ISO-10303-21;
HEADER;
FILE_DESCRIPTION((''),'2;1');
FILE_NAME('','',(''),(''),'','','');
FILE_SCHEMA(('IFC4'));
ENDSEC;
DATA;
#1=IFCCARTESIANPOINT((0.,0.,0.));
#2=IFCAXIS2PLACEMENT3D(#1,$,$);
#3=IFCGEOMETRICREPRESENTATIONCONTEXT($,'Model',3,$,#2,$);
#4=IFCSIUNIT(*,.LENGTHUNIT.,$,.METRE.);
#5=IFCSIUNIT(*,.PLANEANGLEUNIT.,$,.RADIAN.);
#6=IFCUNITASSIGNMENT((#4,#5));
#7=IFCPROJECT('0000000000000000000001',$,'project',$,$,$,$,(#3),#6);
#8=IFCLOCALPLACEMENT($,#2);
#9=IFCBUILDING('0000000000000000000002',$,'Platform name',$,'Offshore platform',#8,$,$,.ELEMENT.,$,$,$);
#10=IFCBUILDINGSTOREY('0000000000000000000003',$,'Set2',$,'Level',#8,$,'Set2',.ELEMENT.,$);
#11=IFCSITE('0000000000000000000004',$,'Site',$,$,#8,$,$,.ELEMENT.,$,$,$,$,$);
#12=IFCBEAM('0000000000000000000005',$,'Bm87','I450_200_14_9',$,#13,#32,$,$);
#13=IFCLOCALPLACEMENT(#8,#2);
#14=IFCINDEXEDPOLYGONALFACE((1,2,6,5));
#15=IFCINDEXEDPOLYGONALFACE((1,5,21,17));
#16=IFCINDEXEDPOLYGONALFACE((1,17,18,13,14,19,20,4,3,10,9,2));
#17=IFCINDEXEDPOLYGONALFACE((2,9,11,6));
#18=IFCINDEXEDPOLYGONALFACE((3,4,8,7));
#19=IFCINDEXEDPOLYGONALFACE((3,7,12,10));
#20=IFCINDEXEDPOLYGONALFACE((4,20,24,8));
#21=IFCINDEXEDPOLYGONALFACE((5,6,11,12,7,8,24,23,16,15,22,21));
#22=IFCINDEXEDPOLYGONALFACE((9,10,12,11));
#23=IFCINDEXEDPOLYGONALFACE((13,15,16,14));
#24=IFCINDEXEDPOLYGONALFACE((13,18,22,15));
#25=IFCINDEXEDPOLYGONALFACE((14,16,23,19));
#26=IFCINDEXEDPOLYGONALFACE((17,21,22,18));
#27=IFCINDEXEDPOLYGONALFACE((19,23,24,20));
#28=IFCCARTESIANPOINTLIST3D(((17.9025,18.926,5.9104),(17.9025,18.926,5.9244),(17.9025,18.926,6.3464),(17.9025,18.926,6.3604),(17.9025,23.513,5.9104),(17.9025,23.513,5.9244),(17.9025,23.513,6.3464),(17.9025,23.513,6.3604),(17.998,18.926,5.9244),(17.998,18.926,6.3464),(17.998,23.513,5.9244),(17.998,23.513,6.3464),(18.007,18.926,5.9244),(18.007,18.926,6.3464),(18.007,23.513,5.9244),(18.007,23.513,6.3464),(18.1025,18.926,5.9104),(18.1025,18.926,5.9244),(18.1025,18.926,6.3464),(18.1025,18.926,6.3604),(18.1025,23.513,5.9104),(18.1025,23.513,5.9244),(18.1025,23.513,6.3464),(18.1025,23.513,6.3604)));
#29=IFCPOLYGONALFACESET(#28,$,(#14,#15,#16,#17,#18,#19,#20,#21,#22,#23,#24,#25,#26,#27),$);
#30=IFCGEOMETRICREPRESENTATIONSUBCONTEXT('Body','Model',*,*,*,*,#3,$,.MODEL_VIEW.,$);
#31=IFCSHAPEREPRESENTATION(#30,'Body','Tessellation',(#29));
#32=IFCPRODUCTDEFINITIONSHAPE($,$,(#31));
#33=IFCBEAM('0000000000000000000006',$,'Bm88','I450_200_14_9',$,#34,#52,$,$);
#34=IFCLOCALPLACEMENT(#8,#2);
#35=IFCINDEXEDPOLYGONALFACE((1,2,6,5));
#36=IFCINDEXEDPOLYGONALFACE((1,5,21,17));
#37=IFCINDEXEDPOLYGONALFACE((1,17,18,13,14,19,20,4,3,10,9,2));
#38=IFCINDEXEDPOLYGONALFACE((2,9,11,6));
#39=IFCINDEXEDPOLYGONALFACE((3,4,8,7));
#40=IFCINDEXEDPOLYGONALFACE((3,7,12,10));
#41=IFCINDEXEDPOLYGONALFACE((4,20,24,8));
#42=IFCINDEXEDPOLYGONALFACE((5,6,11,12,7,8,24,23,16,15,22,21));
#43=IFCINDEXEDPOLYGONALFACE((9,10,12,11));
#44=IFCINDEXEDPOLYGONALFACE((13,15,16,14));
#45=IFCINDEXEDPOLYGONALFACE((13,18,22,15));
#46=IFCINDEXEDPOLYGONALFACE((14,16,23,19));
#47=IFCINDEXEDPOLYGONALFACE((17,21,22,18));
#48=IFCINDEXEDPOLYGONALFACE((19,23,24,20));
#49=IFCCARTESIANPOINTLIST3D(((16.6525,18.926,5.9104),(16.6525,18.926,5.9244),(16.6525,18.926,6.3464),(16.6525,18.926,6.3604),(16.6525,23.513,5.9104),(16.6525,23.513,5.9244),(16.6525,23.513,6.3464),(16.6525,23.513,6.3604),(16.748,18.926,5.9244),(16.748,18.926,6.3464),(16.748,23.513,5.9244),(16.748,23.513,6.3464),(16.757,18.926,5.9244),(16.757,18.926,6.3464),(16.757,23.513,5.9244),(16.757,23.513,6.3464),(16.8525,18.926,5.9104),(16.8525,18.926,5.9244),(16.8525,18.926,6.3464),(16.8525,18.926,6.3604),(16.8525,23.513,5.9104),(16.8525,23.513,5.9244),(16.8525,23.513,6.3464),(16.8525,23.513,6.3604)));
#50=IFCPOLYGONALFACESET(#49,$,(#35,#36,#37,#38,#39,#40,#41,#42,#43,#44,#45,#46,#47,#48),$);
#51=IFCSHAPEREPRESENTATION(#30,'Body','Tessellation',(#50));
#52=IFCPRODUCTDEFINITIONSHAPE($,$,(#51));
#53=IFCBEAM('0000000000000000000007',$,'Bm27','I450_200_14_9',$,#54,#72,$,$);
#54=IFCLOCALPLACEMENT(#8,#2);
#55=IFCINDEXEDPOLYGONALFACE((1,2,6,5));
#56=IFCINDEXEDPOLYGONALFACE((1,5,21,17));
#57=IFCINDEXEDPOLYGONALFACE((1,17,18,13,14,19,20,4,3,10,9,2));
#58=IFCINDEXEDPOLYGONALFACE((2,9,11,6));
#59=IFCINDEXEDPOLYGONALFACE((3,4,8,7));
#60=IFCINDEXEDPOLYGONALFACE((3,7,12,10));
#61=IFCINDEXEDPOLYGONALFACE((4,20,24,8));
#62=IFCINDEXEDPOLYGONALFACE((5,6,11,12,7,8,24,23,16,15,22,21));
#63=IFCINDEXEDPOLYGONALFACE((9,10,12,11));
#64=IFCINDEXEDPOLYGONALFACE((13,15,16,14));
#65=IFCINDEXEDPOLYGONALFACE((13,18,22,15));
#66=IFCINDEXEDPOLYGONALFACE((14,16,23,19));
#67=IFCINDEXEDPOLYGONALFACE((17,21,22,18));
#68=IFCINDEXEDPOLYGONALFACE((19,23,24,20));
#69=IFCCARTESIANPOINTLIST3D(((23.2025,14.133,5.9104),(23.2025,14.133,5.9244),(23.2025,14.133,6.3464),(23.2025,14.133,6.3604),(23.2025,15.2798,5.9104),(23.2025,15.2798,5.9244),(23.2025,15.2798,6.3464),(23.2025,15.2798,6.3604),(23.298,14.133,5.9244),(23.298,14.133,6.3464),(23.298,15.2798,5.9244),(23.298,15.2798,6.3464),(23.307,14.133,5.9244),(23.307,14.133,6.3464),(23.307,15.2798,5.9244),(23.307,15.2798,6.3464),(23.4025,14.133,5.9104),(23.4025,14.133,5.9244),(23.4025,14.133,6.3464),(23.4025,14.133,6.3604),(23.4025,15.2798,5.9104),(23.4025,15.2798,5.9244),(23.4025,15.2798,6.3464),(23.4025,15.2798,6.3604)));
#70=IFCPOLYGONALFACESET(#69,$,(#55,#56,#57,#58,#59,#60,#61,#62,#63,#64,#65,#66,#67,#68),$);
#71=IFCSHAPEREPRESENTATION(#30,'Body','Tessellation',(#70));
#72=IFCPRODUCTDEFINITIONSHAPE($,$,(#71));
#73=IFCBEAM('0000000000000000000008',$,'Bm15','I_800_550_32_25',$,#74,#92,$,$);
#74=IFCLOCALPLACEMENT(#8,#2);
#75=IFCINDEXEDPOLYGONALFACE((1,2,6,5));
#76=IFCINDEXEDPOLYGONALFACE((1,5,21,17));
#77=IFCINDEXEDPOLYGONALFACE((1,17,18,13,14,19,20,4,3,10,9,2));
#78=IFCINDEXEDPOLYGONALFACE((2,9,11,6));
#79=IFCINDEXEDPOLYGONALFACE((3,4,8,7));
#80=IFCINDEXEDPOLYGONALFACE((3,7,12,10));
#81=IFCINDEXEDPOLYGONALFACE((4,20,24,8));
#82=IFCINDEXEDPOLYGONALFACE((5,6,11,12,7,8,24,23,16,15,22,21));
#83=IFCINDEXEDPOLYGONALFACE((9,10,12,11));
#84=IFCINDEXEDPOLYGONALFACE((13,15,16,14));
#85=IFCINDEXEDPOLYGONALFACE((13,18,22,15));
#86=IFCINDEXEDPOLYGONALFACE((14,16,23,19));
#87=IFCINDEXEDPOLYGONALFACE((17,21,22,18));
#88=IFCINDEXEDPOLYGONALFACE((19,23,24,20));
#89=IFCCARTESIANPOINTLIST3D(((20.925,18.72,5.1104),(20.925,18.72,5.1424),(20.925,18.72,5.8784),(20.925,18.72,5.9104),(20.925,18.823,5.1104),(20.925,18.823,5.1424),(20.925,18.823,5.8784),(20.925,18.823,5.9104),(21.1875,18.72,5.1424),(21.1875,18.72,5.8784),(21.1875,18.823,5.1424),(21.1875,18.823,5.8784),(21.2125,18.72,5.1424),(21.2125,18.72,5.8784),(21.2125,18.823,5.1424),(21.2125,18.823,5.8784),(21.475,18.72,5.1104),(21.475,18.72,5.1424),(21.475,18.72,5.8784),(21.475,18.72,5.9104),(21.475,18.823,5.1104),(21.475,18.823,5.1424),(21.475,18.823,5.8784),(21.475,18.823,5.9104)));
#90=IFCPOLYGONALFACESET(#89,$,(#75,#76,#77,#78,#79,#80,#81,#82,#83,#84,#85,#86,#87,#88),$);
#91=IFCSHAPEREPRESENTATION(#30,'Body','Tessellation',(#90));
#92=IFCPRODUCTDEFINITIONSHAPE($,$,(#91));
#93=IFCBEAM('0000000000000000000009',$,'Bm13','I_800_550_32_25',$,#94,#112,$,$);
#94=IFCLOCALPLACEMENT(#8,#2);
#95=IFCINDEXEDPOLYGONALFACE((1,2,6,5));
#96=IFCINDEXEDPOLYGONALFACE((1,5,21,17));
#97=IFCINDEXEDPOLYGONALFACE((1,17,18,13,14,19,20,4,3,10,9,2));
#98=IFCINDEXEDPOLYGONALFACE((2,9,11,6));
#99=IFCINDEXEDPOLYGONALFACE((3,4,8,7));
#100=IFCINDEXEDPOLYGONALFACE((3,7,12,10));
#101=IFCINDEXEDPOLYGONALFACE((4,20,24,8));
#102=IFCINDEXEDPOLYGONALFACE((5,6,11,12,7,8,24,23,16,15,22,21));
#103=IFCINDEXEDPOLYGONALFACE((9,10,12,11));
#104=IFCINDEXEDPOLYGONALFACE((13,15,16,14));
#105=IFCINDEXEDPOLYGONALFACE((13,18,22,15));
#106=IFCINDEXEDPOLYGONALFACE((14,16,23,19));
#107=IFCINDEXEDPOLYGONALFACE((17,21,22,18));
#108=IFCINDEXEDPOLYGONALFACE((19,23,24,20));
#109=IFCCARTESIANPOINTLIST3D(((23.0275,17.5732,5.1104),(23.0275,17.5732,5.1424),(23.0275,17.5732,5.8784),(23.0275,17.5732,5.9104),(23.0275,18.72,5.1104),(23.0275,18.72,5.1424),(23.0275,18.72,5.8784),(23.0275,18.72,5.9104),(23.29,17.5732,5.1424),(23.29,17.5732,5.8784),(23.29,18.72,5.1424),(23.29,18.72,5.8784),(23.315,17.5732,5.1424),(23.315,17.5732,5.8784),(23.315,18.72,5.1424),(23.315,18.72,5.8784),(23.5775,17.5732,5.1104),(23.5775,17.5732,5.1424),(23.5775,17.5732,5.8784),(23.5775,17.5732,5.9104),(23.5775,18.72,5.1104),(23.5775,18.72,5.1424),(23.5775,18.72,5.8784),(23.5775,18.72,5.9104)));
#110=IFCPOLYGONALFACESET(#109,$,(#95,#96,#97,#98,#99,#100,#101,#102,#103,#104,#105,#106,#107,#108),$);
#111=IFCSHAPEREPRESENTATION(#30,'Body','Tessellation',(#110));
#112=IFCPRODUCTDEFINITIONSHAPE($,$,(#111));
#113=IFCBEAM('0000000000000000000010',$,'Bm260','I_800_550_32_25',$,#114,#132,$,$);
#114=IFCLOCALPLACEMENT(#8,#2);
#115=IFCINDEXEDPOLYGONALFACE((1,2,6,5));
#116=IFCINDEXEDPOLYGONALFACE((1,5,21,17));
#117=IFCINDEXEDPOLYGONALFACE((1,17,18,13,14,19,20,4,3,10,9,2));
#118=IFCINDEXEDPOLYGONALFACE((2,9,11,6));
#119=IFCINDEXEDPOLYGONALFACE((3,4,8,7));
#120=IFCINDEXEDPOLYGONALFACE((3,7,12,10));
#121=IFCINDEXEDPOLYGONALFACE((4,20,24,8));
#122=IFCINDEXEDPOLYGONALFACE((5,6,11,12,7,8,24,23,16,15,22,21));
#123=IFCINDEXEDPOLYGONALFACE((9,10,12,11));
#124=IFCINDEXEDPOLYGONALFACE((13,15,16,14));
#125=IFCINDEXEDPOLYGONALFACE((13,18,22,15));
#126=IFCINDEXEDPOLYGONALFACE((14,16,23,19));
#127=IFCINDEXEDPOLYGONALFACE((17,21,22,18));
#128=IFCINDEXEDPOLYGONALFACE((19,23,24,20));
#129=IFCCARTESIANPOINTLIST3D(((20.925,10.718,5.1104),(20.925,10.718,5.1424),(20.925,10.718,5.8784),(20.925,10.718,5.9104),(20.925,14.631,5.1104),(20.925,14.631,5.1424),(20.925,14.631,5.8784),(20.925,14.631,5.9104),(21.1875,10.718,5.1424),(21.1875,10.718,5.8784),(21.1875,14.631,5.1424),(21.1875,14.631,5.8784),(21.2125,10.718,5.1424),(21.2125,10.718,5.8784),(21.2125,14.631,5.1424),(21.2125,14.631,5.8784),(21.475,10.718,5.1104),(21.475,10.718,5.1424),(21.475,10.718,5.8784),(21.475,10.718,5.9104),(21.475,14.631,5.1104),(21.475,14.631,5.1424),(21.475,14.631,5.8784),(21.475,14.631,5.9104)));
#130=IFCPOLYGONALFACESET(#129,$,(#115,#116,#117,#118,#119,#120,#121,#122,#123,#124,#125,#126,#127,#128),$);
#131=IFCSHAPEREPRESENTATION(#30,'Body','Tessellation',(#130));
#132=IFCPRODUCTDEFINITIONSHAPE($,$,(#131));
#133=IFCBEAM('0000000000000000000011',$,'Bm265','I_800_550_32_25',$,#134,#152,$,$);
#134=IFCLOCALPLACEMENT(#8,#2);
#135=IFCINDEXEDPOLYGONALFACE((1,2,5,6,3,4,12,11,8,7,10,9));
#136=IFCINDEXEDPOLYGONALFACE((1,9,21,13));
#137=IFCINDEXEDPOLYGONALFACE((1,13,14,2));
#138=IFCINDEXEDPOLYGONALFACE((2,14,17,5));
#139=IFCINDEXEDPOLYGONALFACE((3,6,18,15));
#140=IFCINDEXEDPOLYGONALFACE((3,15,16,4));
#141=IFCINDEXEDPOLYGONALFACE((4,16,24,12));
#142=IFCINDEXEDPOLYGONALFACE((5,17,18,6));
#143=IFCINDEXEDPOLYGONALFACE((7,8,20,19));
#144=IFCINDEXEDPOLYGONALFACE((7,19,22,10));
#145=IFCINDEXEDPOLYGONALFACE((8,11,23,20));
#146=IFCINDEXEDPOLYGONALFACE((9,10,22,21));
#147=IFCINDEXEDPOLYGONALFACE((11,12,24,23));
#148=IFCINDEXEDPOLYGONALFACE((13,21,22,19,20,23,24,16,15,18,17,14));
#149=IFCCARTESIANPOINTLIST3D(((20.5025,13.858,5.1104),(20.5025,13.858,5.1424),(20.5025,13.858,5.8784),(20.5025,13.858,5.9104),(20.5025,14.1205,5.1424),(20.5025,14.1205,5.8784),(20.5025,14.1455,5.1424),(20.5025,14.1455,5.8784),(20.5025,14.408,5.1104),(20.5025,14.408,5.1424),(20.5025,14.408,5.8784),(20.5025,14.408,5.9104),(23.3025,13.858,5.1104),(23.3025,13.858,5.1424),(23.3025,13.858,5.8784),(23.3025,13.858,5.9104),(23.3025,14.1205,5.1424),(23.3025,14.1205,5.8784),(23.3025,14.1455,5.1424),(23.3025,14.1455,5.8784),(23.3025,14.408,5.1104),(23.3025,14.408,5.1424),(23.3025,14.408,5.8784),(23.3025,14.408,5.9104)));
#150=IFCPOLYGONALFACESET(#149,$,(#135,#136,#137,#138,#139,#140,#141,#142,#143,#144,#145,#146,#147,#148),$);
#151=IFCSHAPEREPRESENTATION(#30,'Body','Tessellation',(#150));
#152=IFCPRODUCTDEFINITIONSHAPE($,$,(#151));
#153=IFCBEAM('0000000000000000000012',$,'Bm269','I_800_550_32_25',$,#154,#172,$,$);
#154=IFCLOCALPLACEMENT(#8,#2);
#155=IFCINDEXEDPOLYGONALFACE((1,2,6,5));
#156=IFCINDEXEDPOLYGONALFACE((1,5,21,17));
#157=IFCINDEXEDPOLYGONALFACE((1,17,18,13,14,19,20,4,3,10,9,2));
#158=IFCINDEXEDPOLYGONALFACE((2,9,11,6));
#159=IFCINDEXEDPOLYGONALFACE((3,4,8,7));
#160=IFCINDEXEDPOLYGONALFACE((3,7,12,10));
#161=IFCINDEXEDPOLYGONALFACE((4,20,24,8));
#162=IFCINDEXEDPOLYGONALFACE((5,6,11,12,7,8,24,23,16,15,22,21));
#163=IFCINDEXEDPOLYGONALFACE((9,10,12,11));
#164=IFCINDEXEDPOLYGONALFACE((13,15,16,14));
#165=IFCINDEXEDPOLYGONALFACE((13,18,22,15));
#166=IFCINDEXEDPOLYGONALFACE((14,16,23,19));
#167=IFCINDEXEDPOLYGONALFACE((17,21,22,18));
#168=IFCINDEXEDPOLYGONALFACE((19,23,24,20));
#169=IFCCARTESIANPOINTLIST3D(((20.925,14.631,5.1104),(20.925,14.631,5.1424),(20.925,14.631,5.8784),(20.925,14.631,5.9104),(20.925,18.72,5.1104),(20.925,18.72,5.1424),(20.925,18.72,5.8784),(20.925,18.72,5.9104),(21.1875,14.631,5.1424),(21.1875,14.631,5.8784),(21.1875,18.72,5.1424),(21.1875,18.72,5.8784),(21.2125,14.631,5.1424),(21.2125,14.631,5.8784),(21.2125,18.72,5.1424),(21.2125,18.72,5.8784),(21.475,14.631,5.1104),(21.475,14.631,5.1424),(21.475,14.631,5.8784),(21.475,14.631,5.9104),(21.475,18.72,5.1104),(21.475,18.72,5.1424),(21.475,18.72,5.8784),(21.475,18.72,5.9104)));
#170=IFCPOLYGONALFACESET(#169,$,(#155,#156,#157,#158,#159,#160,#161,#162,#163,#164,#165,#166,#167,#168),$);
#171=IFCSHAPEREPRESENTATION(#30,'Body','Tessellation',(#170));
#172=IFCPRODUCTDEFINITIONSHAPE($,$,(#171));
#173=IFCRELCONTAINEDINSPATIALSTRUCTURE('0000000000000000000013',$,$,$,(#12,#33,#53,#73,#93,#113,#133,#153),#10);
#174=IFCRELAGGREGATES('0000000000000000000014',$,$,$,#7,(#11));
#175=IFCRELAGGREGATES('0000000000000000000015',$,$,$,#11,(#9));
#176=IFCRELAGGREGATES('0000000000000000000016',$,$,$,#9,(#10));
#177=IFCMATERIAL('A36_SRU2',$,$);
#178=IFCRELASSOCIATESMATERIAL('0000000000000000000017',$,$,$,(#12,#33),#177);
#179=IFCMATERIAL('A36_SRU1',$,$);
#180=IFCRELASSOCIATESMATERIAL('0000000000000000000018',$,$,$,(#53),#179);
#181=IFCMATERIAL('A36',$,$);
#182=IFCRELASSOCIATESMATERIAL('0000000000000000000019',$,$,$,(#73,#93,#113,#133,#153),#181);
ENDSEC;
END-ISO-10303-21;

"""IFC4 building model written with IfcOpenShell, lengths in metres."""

from ifc_helpers import new_model, si_unit, frame, origin, origin_2d, place, context, subcontext, project, spatial, i_section, extrude, source, transform, mapped, material, element, save


model = new_model("IFC4")

# Units and contexts
model_context = context("Model", 3, world=origin())
body_context = subcontext(model_context, "Body", "Model", "MODEL_VIEW")
ifc_project = project(units=[si_unit("LENGTHUNIT", "METRE"), si_unit("PLANEANGLEUNIT", "RADIAN")], contexts=[model_context])

# Site, building, storey
placement_1 = place(None, origin())
site = spatial("IfcSite", under=ifc_project, at=placement_1, Name="Site", CompositionType="ELEMENT")
building = spatial("IfcBuilding", under=site, at=placement_1, Name="Platform name", ObjectType="Offshore platform", CompositionType="ELEMENT")
storey = spatial("IfcBuildingStorey", under=building, at=placement_1, Name="Set2", ObjectType="Level", LongName="Set2", CompositionType="ELEMENT")

# Beams
ifc_material_1 = material(Name="A36")
ifc_material_2 = material(Name="A36_SRU1")
ifc_material_3 = material(Name="A36_SRU2")
shared_shape_1 = source(origin(), body_context, "Body", "SweptSolid", [
    extrude(i_section(OverallWidth=0.2, OverallDepth=0.45, WebThickness=0.009, FlangeThickness=0.014, FilletRadius=0.0, at=origin_2d()), frame((0.0, 0.0, 0.0), z_axis=(0.0, 1.0, 0.0), x_axis=(-1.0, 0.0, 0.0)), (0.0, 0.0, 1.0), 4.587),
])
placement_2 = place(None, origin())
placement_3 = place(placement_2, origin())
placement_4 = place(placement_3, origin())
beam_1_placement = place(placement_4, frame((18.0025, 18.926, 6.1354)))
element("IfcBeam", 1, at=beam_1_placement, inside=storey, material=ifc_material_3, Name="Bm87", Description="I450_200_14_9", context=body_context, shape_type="MappedRepresentation", body=[
    mapped(shared_shape_1, transform((0.0, 0.0, 0.0), scale=1.0)),
])
shared_shape_2 = source(origin(), body_context, "Body", "SweptSolid", [
    extrude(i_section(OverallWidth=0.2, OverallDepth=0.45, WebThickness=0.009, FlangeThickness=0.014, FilletRadius=0.0, at=origin_2d()), frame((0.0, 0.0, 0.0), z_axis=(0.0, 1.0, 0.0), x_axis=(-1.0, 0.0, 0.0)), (0.0, 0.0, 1.0), 4.587),
])
placement_5 = place(None, origin())
placement_6 = place(placement_5, origin())
placement_7 = place(placement_6, origin())
beam_2_placement = place(placement_7, frame((16.7525, 18.926, 6.1354)))
element("IfcBeam", 2, at=beam_2_placement, inside=storey, material=ifc_material_3, Name="Bm88", Description="I450_200_14_9", context=body_context, shape_type="MappedRepresentation", body=[
    mapped(shared_shape_2, transform((0.0, 0.0, 0.0), scale=1.0)),
])
shared_shape_3 = source(origin(), body_context, "Body", "SweptSolid", [
    extrude(i_section(OverallWidth=0.2, OverallDepth=0.45, WebThickness=0.009, FlangeThickness=0.014, FilletRadius=0.0, at=origin_2d()), frame((0.0, 0.0, 0.0), z_axis=(0.0, 1.0, 0.0), x_axis=(-1.0, 0.0, 0.0)), (0.0, 0.0, 1.0), 1.1467),
])
placement_8 = place(None, origin())
placement_9 = place(placement_8, origin())
placement_10 = place(placement_9, origin())
beam_3_placement = place(placement_10, frame((23.3025, 14.133, 6.1354)))
element("IfcBeam", 3, at=beam_3_placement, inside=storey, material=ifc_material_2, Name="Bm27", Description="I450_200_14_9", context=body_context, shape_type="MappedRepresentation", body=[
    mapped(shared_shape_3, transform((0.0, 0.0, 0.0), scale=1.0)),
])
shared_shape_4 = source(origin(), body_context, "Body", "SweptSolid", [
    extrude(i_section(OverallWidth=0.55, OverallDepth=0.8, WebThickness=0.025, FlangeThickness=0.032, FilletRadius=0.0, at=origin_2d()), frame((0.0, 0.0, 0.0), z_axis=(0.0, -1.0, 0.0), x_axis=(1.0, 0.0, 0.0)), (0.0, 0.0, 1.0), 0.103),
])
placement_11 = place(None, origin())
placement_12 = place(placement_11, origin())
placement_13 = place(placement_12, origin())
beam_4_placement = place(placement_13, frame((21.2, 18.823, 5.5104)))
element("IfcBeam", 4, at=beam_4_placement, inside=storey, material=ifc_material_1, Name="Bm15", Description="I_800_550_32_25", context=body_context, shape_type="MappedRepresentation", body=[
    mapped(shared_shape_4, transform((0.0, 0.0, 0.0), scale=1.0)),
])
shared_shape_5 = source(origin(), body_context, "Body", "SweptSolid", [
    extrude(i_section(OverallWidth=0.55, OverallDepth=0.8, WebThickness=0.025, FlangeThickness=0.032, FilletRadius=0.0, at=origin_2d()), frame((0.0, 0.0, 0.0), z_axis=(0.0, -1.0, 0.0), x_axis=(1.0, 0.0, 0.0)), (0.0, 0.0, 1.0), 1.1467),
])
placement_14 = place(None, origin())
placement_15 = place(placement_14, origin())
placement_16 = place(placement_15, origin())
beam_5_placement = place(placement_16, frame((23.3025, 18.72, 5.5104)))
element("IfcBeam", 5, at=beam_5_placement, inside=storey, material=ifc_material_1, Name="Bm13", Description="I_800_550_32_25", context=body_context, shape_type="MappedRepresentation", body=[
    mapped(shared_shape_5, transform((0.0, 0.0, 0.0), scale=1.0)),
])
shared_shape_6 = source(origin(), body_context, "Body", "SweptSolid", [
    extrude(i_section(OverallWidth=0.55, OverallDepth=0.8, WebThickness=0.025, FlangeThickness=0.032, FilletRadius=0.0, at=origin_2d()), frame((0.0, 0.0, 0.0), z_axis=(0.0, -1.0, 0.0), x_axis=(1.0, 0.0, 0.0)), (0.0, 0.0, 1.0), 3.913),
])
placement_17 = place(None, origin())
placement_18 = place(placement_17, origin())
placement_19 = place(placement_18, origin())
beam_6_placement = place(placement_19, frame((21.2, 14.631, 5.5104)))
element("IfcBeam", 6, at=beam_6_placement, inside=storey, material=ifc_material_1, Name="Bm260", Description="I_800_550_32_25", context=body_context, shape_type="MappedRepresentation", body=[
    mapped(shared_shape_6, transform((0.0, 0.0, 0.0), scale=1.0)),
])
shared_shape_7 = source(origin(), body_context, "Body", "SweptSolid", [
    extrude(i_section(OverallWidth=0.55, OverallDepth=0.8, WebThickness=0.025, FlangeThickness=0.032, FilletRadius=0.0, at=origin_2d()), frame((0.0, 0.0, 0.0), z_axis=(1.0, 0.0, 0.0), x_axis=(0.0, 1.0, 0.0)), (0.0, 0.0, 1.0), 2.8),
])
placement_20 = place(None, origin())
placement_21 = place(placement_20, origin())
placement_22 = place(placement_21, origin())
beam_7_placement = place(placement_22, frame((20.5025, 14.133, 5.5104)))
element("IfcBeam", 7, at=beam_7_placement, inside=storey, material=ifc_material_1, Name="Bm265", Description="I_800_550_32_25", context=body_context, shape_type="MappedRepresentation", body=[
    mapped(shared_shape_7, transform((0.0, 0.0, 0.0), scale=1.0)),
])
shared_shape_8 = source(origin(), body_context, "Body", "SweptSolid", [
    extrude(i_section(OverallWidth=0.55, OverallDepth=0.8, WebThickness=0.025, FlangeThickness=0.032, FilletRadius=0.0, at=origin_2d()), frame((0.0, 0.0, 0.0), z_axis=(0.0, -1.0, 0.0), x_axis=(1.0, 0.0, 0.0)), (0.0, 0.0, 1.0), 4.089),
])
placement_23 = place(None, origin())
placement_24 = place(placement_23, origin())
placement_25 = place(placement_24, origin())
beam_8_placement = place(placement_25, frame((21.2, 18.72, 5.5104)))
element("IfcBeam", 8, at=beam_8_placement, inside=storey, material=ifc_material_1, Name="Bm269", Description="I_800_550_32_25", context=body_context, shape_type="MappedRepresentation", body=[
    mapped(shared_shape_8, transform((0.0, 0.0, 0.0), scale=1.0)),
])

save(model, "model.ifc")
